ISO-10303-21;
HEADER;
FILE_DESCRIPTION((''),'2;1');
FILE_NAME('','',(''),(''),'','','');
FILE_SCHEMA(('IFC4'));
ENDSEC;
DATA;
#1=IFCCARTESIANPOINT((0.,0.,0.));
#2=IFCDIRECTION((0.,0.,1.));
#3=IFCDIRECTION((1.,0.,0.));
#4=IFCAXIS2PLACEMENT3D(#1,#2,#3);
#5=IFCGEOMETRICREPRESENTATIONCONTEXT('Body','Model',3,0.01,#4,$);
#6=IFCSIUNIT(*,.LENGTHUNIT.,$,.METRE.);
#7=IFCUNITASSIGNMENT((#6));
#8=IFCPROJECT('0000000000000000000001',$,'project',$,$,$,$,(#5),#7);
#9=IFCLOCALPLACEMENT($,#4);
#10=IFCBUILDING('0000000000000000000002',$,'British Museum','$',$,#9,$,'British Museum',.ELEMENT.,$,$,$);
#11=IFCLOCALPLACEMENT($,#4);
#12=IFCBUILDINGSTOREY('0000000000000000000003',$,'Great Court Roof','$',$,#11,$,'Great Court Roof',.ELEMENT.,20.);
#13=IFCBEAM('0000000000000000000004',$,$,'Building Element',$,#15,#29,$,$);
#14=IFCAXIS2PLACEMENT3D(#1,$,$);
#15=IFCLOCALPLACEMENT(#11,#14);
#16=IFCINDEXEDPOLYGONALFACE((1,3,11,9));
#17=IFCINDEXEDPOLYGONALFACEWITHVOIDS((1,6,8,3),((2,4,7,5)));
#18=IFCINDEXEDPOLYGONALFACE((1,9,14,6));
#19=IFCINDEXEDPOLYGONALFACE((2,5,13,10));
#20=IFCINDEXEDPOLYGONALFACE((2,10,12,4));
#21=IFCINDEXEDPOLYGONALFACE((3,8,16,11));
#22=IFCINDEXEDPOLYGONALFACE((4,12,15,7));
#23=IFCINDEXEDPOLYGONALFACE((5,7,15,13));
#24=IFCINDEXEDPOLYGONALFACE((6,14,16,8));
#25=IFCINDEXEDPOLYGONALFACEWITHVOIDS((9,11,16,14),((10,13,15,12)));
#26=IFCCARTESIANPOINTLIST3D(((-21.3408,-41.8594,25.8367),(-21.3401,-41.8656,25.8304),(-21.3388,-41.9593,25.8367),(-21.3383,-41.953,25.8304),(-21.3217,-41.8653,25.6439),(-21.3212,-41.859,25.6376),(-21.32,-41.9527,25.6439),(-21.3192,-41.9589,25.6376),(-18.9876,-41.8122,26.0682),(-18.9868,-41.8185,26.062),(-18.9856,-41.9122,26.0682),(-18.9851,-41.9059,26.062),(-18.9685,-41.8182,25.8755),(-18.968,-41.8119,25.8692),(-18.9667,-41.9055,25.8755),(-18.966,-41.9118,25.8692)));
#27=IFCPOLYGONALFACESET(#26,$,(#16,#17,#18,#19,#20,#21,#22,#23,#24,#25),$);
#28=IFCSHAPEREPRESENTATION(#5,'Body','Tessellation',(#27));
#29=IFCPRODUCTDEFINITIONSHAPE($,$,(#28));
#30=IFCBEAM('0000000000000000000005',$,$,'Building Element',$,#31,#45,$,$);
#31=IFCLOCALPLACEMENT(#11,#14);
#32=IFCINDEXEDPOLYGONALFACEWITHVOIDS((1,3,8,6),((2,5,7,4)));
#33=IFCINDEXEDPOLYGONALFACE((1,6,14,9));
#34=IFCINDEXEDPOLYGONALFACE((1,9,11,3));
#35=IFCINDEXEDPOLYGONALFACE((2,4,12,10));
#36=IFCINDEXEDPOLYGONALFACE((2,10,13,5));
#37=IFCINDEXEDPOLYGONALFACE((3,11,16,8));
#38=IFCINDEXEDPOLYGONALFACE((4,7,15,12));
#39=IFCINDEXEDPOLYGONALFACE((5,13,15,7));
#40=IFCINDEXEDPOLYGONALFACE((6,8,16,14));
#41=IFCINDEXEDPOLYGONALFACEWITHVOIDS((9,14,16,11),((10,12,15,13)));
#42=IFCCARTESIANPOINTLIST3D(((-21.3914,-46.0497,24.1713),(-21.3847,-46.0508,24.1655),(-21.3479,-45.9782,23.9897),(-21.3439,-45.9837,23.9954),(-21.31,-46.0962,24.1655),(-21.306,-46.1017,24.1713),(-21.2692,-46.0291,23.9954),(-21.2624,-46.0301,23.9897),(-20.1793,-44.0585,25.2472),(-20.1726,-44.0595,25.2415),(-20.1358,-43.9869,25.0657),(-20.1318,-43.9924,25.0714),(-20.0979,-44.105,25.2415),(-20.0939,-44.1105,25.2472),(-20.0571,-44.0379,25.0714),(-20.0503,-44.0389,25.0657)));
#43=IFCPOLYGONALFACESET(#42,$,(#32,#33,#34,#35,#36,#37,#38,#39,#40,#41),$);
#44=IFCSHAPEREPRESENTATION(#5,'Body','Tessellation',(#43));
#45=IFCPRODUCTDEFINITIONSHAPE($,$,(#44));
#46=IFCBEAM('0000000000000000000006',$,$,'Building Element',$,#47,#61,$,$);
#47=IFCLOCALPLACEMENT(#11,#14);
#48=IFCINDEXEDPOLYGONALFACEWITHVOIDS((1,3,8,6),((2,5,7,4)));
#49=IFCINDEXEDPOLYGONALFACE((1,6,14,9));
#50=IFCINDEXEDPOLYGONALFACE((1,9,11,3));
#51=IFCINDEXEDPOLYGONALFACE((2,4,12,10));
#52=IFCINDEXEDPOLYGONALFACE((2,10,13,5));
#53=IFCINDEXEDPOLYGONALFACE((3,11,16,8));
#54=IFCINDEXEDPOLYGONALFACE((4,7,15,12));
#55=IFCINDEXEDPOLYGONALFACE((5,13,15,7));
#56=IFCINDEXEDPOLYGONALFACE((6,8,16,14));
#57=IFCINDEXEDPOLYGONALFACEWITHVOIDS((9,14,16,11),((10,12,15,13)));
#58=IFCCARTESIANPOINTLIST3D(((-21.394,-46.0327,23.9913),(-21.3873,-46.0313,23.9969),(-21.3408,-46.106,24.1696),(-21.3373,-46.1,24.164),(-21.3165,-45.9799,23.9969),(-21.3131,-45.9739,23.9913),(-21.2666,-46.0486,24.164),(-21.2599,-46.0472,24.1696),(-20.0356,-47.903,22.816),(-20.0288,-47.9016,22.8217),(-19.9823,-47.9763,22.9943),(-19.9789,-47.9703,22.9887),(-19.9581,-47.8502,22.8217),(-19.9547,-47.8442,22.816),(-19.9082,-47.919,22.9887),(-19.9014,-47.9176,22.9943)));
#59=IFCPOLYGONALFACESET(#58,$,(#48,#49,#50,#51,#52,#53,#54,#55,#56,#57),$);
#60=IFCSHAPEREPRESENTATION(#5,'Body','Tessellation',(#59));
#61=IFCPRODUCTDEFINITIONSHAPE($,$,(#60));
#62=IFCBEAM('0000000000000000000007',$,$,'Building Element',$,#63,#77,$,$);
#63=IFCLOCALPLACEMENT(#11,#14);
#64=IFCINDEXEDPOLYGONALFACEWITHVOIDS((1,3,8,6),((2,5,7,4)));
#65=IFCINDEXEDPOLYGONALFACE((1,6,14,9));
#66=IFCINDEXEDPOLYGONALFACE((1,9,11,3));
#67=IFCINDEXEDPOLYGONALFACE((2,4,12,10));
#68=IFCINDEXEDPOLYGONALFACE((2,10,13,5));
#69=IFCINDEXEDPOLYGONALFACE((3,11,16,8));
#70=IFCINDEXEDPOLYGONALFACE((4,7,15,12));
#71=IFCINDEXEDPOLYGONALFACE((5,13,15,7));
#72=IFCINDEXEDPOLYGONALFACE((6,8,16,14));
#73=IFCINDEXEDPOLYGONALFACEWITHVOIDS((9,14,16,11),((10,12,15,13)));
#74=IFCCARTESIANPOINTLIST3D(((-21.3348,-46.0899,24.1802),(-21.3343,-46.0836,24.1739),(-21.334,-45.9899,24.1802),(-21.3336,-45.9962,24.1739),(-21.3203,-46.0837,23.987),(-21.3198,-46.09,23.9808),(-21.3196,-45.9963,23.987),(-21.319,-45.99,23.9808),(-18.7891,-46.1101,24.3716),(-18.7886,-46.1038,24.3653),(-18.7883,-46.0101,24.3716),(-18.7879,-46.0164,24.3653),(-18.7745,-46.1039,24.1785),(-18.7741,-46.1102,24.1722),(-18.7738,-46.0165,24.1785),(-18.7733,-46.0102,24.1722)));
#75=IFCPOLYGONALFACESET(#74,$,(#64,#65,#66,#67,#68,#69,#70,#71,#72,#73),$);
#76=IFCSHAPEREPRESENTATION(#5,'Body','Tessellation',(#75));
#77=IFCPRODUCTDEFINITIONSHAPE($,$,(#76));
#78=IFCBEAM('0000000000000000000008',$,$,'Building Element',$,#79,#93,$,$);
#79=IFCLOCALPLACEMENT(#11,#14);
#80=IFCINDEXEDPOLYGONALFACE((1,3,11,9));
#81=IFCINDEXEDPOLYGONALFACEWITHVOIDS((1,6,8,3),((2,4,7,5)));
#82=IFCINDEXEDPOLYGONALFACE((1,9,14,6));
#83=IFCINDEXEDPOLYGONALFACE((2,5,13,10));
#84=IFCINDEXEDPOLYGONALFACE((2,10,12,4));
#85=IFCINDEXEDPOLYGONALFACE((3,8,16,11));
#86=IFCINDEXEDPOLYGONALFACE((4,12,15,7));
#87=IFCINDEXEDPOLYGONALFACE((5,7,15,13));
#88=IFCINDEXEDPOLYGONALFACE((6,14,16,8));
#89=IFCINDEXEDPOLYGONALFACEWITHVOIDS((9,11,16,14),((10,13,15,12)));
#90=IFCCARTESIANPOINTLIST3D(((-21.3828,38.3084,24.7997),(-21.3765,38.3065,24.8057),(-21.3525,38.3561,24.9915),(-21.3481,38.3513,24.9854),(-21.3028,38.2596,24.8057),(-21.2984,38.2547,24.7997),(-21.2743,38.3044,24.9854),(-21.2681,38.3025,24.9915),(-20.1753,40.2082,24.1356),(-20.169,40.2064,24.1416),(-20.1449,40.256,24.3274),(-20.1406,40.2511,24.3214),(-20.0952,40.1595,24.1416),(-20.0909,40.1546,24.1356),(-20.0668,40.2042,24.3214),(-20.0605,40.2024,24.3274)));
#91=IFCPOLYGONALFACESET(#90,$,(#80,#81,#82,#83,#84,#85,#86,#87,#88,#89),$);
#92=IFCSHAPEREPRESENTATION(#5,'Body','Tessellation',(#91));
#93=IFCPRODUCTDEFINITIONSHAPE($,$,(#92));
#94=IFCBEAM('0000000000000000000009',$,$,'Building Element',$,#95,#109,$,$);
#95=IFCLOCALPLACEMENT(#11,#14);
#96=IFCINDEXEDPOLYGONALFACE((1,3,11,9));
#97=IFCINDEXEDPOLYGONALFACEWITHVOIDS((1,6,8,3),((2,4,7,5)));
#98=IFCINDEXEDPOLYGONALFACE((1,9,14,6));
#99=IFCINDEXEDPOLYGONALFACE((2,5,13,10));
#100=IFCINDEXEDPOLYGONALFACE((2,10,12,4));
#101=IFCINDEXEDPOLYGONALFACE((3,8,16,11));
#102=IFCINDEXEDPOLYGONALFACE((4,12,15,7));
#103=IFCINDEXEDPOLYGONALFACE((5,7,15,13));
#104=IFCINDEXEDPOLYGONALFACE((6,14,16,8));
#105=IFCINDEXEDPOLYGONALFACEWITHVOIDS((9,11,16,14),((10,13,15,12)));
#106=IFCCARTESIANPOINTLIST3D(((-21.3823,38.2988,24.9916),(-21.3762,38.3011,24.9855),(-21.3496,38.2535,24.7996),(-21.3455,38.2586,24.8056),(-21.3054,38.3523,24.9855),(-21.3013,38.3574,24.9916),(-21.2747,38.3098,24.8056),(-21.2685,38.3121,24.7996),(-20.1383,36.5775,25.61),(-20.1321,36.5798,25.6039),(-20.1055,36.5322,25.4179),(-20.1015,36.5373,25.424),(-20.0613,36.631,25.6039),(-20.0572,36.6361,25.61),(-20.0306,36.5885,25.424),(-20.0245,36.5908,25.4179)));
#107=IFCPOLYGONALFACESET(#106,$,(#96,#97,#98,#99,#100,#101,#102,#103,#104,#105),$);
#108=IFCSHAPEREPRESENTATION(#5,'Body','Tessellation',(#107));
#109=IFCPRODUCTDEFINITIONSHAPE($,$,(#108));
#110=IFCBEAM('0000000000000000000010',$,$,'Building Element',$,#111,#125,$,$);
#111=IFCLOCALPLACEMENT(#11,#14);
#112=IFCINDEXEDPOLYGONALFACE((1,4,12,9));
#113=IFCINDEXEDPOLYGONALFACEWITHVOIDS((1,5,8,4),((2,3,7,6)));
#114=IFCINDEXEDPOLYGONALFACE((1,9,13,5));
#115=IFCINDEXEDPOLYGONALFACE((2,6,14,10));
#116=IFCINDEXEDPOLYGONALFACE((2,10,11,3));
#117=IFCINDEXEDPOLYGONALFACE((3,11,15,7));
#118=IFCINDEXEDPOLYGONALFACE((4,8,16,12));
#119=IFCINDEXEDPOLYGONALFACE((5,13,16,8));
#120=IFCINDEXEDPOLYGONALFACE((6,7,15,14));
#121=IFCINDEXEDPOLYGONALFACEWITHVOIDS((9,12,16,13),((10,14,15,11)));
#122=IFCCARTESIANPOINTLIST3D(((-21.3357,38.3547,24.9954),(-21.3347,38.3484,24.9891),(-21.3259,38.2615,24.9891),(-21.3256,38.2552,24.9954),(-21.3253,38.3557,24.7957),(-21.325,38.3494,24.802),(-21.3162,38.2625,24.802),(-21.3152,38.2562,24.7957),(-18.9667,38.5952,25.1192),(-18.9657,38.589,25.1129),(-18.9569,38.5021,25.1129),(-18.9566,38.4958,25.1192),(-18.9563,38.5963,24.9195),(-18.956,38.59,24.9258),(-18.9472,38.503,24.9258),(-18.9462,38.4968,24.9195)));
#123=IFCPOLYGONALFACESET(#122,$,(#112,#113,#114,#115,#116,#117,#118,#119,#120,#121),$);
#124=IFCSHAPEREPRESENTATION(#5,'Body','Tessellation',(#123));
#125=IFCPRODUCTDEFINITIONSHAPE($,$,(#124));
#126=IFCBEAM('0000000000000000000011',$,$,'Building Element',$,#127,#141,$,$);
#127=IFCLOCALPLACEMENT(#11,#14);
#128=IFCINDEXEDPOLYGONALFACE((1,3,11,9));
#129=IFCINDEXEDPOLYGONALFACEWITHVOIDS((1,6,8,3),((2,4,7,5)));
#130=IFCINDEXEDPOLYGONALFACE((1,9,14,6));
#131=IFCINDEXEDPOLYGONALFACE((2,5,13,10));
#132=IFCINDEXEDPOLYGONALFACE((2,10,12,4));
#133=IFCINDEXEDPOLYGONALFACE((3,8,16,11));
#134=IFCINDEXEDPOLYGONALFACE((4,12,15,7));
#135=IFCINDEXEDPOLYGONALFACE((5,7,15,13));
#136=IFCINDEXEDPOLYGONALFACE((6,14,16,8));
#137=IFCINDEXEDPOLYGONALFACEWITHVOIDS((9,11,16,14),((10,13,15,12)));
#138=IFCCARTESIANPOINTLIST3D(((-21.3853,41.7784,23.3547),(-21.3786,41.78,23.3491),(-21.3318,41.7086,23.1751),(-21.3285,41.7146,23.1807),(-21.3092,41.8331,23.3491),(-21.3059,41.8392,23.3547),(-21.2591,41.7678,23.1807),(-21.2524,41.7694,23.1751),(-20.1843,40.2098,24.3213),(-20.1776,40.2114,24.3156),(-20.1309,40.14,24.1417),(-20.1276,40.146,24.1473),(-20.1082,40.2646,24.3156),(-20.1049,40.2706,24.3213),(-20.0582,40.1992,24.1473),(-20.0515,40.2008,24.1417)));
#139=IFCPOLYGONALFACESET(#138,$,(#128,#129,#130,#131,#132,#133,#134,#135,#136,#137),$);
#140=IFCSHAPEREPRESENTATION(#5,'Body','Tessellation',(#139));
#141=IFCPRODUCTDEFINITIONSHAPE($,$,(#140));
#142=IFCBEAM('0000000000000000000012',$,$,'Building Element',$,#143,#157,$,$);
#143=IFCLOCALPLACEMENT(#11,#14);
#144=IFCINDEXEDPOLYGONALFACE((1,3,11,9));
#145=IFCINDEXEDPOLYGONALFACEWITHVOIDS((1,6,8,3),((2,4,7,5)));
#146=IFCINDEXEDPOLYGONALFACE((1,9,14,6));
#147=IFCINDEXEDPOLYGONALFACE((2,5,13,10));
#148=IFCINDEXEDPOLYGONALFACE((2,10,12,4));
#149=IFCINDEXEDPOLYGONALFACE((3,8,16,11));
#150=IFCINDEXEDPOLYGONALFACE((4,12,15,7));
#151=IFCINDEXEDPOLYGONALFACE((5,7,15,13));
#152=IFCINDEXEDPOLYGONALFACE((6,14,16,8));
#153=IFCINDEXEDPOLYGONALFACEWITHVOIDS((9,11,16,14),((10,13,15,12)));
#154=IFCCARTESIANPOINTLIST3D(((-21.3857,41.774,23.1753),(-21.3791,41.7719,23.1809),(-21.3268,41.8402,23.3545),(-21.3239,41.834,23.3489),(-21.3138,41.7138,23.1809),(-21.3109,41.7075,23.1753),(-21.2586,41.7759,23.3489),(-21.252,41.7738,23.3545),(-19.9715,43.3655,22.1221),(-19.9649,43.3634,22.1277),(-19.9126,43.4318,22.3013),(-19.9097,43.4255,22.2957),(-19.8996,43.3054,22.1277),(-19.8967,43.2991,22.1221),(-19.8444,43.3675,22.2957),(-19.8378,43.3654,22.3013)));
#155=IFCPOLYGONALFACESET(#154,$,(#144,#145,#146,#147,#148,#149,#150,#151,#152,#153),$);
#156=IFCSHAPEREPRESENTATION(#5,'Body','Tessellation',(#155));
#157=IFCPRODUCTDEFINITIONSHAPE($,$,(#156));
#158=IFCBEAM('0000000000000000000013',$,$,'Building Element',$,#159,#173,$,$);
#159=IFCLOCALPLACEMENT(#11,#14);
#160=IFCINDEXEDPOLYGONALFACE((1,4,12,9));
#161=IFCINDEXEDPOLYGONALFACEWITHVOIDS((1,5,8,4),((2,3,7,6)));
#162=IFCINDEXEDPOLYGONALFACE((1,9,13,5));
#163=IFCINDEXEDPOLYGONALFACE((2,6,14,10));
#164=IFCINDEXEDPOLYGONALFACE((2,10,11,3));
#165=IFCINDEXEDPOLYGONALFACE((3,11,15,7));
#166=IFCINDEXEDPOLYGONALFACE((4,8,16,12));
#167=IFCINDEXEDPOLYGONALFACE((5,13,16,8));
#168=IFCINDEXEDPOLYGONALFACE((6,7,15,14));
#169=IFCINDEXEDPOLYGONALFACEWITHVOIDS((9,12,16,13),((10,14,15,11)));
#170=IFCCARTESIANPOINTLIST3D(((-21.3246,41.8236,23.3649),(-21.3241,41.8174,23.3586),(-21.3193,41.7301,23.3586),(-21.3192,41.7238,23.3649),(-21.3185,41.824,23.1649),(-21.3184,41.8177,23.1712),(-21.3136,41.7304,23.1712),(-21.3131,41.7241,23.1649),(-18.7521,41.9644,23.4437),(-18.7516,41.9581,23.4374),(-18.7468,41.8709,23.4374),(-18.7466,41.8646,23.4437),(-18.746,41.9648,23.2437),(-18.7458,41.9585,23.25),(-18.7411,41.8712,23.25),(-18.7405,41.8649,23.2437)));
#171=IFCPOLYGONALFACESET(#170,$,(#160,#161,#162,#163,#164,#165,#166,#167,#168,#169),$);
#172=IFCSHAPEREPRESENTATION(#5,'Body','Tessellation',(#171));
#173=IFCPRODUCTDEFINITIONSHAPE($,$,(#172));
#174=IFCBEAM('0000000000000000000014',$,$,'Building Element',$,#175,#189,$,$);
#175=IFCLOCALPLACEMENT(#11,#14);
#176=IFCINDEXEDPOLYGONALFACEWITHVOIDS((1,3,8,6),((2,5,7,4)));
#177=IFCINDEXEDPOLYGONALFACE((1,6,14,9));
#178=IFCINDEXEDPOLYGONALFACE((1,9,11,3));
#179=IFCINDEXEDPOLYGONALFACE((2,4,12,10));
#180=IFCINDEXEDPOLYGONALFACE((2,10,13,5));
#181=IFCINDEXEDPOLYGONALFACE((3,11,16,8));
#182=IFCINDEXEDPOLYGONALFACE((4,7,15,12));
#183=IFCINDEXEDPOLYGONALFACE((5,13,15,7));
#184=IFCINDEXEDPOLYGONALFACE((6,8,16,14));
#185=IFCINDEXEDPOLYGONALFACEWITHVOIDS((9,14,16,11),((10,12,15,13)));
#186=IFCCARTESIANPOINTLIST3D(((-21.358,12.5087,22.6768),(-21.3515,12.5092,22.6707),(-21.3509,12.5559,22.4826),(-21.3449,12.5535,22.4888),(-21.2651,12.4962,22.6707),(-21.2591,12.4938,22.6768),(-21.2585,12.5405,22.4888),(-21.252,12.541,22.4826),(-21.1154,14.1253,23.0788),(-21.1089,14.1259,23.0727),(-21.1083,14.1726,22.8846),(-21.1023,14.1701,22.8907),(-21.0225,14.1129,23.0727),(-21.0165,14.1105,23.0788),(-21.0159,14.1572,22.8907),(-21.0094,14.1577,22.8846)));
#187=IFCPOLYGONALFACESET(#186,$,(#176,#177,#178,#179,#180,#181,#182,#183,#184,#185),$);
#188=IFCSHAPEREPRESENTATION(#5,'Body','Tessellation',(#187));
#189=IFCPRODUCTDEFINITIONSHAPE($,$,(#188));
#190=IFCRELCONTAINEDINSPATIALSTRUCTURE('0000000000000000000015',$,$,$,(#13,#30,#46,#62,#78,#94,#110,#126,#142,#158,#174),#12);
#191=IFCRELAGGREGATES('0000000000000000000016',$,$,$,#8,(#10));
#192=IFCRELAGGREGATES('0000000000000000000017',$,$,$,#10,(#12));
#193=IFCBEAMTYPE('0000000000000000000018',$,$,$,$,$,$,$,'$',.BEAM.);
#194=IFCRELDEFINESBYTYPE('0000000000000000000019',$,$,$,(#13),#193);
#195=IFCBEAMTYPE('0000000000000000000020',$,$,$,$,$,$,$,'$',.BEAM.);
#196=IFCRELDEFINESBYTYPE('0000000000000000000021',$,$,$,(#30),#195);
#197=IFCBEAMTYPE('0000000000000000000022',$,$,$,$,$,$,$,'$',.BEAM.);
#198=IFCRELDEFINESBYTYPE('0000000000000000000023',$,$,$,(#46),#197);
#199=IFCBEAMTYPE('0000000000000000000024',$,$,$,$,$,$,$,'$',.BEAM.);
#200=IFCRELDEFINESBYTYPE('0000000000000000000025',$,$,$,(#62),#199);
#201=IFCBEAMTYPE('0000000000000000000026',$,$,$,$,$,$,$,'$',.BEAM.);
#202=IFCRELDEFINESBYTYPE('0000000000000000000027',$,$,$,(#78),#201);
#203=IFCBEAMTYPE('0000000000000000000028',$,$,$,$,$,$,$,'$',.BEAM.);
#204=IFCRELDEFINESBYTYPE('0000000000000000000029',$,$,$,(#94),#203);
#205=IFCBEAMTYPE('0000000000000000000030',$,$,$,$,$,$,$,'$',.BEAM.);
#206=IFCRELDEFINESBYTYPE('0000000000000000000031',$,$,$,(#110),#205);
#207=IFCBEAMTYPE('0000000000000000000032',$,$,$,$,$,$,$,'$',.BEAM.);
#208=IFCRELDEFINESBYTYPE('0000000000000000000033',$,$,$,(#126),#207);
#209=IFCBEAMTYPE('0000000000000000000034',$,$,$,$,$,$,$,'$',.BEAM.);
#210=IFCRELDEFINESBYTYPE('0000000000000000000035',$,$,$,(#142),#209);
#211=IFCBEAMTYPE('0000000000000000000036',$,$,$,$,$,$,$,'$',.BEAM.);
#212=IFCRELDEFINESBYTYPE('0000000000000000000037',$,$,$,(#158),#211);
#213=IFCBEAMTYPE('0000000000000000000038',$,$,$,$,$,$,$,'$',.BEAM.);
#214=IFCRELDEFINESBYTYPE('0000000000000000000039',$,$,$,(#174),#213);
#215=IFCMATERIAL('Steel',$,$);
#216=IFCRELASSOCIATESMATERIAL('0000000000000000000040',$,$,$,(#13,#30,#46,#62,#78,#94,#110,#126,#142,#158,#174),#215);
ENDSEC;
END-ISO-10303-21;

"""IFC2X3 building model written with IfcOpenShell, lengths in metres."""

from ifc_helpers import new_model, si_unit, frame, origin_with_axes, origin_2d, place, context, project, spatial, hollow_rectangle, extrude, material, type_object, element, save


model = new_model("IFC2X3")

# Units and contexts
model_context = context("Model", 3, precision=0.01, world=origin_with_axes(), identifier="Body")
ifc_project = project(units=[si_unit("LENGTHUNIT", "METRE")], contexts=[model_context])

# Building, storey
building_placement = place(None, origin_with_axes())
building = spatial("IfcBuilding", under=ifc_project, at=building_placement, Name="British Museum", Description="$", LongName="British Museum", CompositionType="ELEMENT")
storey_placement = place(None, origin_with_axes())
storey = spatial("IfcBuildingStorey", under=building, at=storey_placement, Name="Great Court Roof", Description="$", LongName="Great Court Roof", CompositionType="ELEMENT", Elevation=20.0)

# Beams
ifc_material = material(Name="Steel")
beam_type_1 = type_object("IfcBeamType", ElementType="$", PredefinedType="BEAM")
beam_1_placement = place(None, origin_with_axes())
element("IfcBeam", 1, at=beam_1_placement, inside=storey, type_object=beam_type_1, material=ifc_material, Description="Building Element", context=model_context, shape_type="SweptSolid", body=[
    extrude(hollow_rectangle(XDim=0.1, YDim=0.2, WallThickness=0.0063, InnerFilletRadius=-0.0063, OuterFilletRadius=0.0, at=origin_2d()), frame((-21.33, -41.9092, 25.7372), z_axis=(0.994996, 0.019921, 0.09791), x_axis=(-0.020018, 0.9998, 0.0)), (0.0, 0.0, 1.0), 2.365),
])
beam_type_2 = type_object("IfcBeamType", ElementType="$", PredefinedType="BEAM")
beam_2_placement = place(None, origin_with_axes())
element("IfcBeam", 2, at=beam_2_placement, inside=storey, type_object=beam_type_2, material=ifc_material, Description="Building Element", context=model_context, shape_type="SweptSolid", body=[
    extrude(hollow_rectangle(XDim=0.1, YDim=0.2, WallThickness=0.0063, InnerFilletRadius=-0.0063, OuterFilletRadius=0.0, at=origin_2d()), frame((-21.3269, -46.0399, 24.0805), z_axis=(0.472098, 0.775561, 0.419081), x_axis=(-0.85419, 0.519961, 0.0)), (0.0, 0.0, 1.0), 2.5675),
])
beam_type_3 = type_object("IfcBeamType", ElementType="$", PredefinedType="BEAM")
beam_3_placement = place(None, origin_with_axes())
element("IfcBeam", 3, at=beam_3_placement, inside=storey, type_object=beam_type_3, material=ifc_material, Description="Building Element", context=model_context, shape_type="SweptSolid", body=[
    extrude(hollow_rectangle(XDim=0.1, YDim=0.2, WallThickness=0.0063, InnerFilletRadius=-0.0063, OuterFilletRadius=0.0, at=origin_2d()), frame((-21.3269, -46.0399, 24.0805), z_axis=(0.523849, -0.721235, -0.453214), x_axis=(0.809102, 0.587668, 0.0)), (0.0, 0.0, 1.0), 2.5932),
])
beam_type_4 = type_object("IfcBeamType", ElementType="$", PredefinedType="BEAM")
beam_4_placement = place(None, origin_with_axes())
element("IfcBeam", 4, at=beam_4_placement, inside=storey, type_object=beam_type_4, material=ifc_material, Description="Building Element", context=model_context, shape_type="SweptSolid", body=[
    extrude(hollow_rectangle(XDim=0.1, YDim=0.2, WallThickness=0.0063, InnerFilletRadius=-0.0063, OuterFilletRadius=0.0, at=origin_2d()), frame((-21.3269, -46.0399, 24.0805), z_axis=(0.997154, -0.007898, 0.07498), x_axis=(0.00792, 0.999969, 0.0)), (0.0, 0.0, 1.0), 2.553),
])
beam_type_5 = type_object("IfcBeamType", ElementType="$", PredefinedType="BEAM")
beam_5_placement = place(None, origin_with_axes())
element("IfcBeam", 5, at=beam_5_placement, inside=storey, type_object=beam_type_5, material=ifc_material, Description="Building Element", context=model_context, shape_type="SweptSolid", body=[
    extrude(hollow_rectangle(XDim=0.1, YDim=0.2, WallThickness=0.0063, InnerFilletRadius=-0.0063, OuterFilletRadius=0.0, at=origin_2d()), frame((-21.3254, 38.3054, 24.8956), z_axis=(0.514496, 0.809465, -0.282949), x_axis=(-0.843953, 0.536417, 0.0)), (0.0, 0.0, 1.0), 2.347),
])
beam_type_6 = type_object("IfcBeamType", ElementType="$", PredefinedType="BEAM")
beam_6_placement = place(None, origin_with_axes())
element("IfcBeam", 6, at=beam_6_placement, inside=storey, type_object=beam_type_6, material=ifc_material, Description="Building Element", context=model_context, shape_type="SweptSolid", body=[
    extrude(hollow_rectangle(XDim=0.1, YDim=0.2, WallThickness=0.0063, InnerFilletRadius=-0.0063, OuterFilletRadius=0.0, at=origin_2d()), frame((-21.3254, 38.3054, 24.8956), z_axis=(0.562418, -0.778161, 0.279558), x_axis=(0.810475, 0.585773, 0.0)), (0.0, 0.0, 1.0), 2.212),
])
beam_type_7 = type_object("IfcBeamType", ElementType="$", PredefinedType="BEAM")
beam_7_placement = place(None, origin_with_axes())
element("IfcBeam", 7, at=beam_7_placement, inside=storey, type_object=beam_type_7, material=ifc_material, Description="Building Element", context=model_context, shape_type="SweptSolid", body=[
    extrude(hollow_rectangle(XDim=0.1, YDim=0.2, WallThickness=0.0063, InnerFilletRadius=-0.0063, OuterFilletRadius=0.0, at=origin_2d()), frame((-21.3254, 38.3054, 24.8956), z_axis=(0.993542, 0.100895, 0.051906), x_axis=(-0.101032, 0.994883, 0.0)), (0.0, 0.0, 1.0), 2.3844),
])
beam_type_8 = type_object("IfcBeamType", ElementType="$", PredefinedType="BEAM")
beam_8_placement = place(None, origin_with_axes())
element("IfcBeam", 8, at=beam_8_placement, inside=storey, type_object=beam_type_8, material=ifc_material, Description="Building Element", context=model_context, shape_type="SweptSolid", body=[
    extrude(hollow_rectangle(XDim=0.1, YDim=0.2, WallThickness=0.0063, InnerFilletRadius=-0.0063, OuterFilletRadius=0.0, at=origin_2d()), frame((-21.3189, 41.7739, 23.2649), z_axis=(0.546054, -0.713214, 0.43949), x_axis=(0.794006, 0.60791, 0.0)), (0.0, 0.0, 1.0), 2.1993),
])
beam_type_9 = type_object("IfcBeamType", ElementType="$", PredefinedType="BEAM")
beam_9_placement = place(None, origin_with_axes())
element("IfcBeam", 9, at=beam_9_placement, inside=storey, type_object=beam_type_9, material=ifc_material, Description="Building Element", context=model_context, shape_type="SweptSolid", body=[
    extrude(hollow_rectangle(XDim=0.1, YDim=0.2, WallThickness=0.0063, InnerFilletRadius=-0.0063, OuterFilletRadius=0.0, at=origin_2d()), frame((-21.3189, 41.7739, 23.2649), z_axis=(0.59537, 0.67003, -0.44339), x_axis=(-0.747527, 0.664232, 0.0)), (0.0, 0.0, 1.0), 2.3753),
])
beam_type_10 = type_object("IfcBeamType", ElementType="$", PredefinedType="BEAM")
beam_10_placement = place(None, origin_with_axes())
element("IfcBeam", 10, at=beam_10_placement, inside=storey, type_object=beam_type_10, material=ifc_material, Description="Building Element", context=model_context, shape_type="SweptSolid", body=[
    extrude(hollow_rectangle(XDim=0.1, YDim=0.2, WallThickness=0.0063, InnerFilletRadius=-0.0063, OuterFilletRadius=0.0, at=origin_2d()), frame((-21.3189, 41.7739, 23.2649), z_axis=(0.998039, 0.054619, 0.030571), x_axis=(-0.054644, 0.998506, 0.0)), (0.0, 0.0, 1.0), 2.5776),
])
beam_type_11 = type_object("IfcBeamType", ElementType="$", PredefinedType="BEAM")
beam_11_placement = place(None, origin_with_axes())
element("IfcBeam", 11, at=beam_11_placement, inside=storey, type_object=beam_type_11, material=ifc_material, Description="Building Element", context=model_context, shape_type="SweptSolid", body=[
    extrude(hollow_rectangle(XDim=0.1, YDim=0.2, WallThickness=0.0063, InnerFilletRadius=-0.0063, OuterFilletRadius=0.0, at=origin_2d()), frame((-21.305, 12.5249, 22.5797), z_axis=(0.144105, 0.960326, 0.238764), x_axis=(-0.988928, 0.148397, 0.0)), (0.0, 0.0, 1.0), 1.6835),
])

save(model, "model.ifc")
